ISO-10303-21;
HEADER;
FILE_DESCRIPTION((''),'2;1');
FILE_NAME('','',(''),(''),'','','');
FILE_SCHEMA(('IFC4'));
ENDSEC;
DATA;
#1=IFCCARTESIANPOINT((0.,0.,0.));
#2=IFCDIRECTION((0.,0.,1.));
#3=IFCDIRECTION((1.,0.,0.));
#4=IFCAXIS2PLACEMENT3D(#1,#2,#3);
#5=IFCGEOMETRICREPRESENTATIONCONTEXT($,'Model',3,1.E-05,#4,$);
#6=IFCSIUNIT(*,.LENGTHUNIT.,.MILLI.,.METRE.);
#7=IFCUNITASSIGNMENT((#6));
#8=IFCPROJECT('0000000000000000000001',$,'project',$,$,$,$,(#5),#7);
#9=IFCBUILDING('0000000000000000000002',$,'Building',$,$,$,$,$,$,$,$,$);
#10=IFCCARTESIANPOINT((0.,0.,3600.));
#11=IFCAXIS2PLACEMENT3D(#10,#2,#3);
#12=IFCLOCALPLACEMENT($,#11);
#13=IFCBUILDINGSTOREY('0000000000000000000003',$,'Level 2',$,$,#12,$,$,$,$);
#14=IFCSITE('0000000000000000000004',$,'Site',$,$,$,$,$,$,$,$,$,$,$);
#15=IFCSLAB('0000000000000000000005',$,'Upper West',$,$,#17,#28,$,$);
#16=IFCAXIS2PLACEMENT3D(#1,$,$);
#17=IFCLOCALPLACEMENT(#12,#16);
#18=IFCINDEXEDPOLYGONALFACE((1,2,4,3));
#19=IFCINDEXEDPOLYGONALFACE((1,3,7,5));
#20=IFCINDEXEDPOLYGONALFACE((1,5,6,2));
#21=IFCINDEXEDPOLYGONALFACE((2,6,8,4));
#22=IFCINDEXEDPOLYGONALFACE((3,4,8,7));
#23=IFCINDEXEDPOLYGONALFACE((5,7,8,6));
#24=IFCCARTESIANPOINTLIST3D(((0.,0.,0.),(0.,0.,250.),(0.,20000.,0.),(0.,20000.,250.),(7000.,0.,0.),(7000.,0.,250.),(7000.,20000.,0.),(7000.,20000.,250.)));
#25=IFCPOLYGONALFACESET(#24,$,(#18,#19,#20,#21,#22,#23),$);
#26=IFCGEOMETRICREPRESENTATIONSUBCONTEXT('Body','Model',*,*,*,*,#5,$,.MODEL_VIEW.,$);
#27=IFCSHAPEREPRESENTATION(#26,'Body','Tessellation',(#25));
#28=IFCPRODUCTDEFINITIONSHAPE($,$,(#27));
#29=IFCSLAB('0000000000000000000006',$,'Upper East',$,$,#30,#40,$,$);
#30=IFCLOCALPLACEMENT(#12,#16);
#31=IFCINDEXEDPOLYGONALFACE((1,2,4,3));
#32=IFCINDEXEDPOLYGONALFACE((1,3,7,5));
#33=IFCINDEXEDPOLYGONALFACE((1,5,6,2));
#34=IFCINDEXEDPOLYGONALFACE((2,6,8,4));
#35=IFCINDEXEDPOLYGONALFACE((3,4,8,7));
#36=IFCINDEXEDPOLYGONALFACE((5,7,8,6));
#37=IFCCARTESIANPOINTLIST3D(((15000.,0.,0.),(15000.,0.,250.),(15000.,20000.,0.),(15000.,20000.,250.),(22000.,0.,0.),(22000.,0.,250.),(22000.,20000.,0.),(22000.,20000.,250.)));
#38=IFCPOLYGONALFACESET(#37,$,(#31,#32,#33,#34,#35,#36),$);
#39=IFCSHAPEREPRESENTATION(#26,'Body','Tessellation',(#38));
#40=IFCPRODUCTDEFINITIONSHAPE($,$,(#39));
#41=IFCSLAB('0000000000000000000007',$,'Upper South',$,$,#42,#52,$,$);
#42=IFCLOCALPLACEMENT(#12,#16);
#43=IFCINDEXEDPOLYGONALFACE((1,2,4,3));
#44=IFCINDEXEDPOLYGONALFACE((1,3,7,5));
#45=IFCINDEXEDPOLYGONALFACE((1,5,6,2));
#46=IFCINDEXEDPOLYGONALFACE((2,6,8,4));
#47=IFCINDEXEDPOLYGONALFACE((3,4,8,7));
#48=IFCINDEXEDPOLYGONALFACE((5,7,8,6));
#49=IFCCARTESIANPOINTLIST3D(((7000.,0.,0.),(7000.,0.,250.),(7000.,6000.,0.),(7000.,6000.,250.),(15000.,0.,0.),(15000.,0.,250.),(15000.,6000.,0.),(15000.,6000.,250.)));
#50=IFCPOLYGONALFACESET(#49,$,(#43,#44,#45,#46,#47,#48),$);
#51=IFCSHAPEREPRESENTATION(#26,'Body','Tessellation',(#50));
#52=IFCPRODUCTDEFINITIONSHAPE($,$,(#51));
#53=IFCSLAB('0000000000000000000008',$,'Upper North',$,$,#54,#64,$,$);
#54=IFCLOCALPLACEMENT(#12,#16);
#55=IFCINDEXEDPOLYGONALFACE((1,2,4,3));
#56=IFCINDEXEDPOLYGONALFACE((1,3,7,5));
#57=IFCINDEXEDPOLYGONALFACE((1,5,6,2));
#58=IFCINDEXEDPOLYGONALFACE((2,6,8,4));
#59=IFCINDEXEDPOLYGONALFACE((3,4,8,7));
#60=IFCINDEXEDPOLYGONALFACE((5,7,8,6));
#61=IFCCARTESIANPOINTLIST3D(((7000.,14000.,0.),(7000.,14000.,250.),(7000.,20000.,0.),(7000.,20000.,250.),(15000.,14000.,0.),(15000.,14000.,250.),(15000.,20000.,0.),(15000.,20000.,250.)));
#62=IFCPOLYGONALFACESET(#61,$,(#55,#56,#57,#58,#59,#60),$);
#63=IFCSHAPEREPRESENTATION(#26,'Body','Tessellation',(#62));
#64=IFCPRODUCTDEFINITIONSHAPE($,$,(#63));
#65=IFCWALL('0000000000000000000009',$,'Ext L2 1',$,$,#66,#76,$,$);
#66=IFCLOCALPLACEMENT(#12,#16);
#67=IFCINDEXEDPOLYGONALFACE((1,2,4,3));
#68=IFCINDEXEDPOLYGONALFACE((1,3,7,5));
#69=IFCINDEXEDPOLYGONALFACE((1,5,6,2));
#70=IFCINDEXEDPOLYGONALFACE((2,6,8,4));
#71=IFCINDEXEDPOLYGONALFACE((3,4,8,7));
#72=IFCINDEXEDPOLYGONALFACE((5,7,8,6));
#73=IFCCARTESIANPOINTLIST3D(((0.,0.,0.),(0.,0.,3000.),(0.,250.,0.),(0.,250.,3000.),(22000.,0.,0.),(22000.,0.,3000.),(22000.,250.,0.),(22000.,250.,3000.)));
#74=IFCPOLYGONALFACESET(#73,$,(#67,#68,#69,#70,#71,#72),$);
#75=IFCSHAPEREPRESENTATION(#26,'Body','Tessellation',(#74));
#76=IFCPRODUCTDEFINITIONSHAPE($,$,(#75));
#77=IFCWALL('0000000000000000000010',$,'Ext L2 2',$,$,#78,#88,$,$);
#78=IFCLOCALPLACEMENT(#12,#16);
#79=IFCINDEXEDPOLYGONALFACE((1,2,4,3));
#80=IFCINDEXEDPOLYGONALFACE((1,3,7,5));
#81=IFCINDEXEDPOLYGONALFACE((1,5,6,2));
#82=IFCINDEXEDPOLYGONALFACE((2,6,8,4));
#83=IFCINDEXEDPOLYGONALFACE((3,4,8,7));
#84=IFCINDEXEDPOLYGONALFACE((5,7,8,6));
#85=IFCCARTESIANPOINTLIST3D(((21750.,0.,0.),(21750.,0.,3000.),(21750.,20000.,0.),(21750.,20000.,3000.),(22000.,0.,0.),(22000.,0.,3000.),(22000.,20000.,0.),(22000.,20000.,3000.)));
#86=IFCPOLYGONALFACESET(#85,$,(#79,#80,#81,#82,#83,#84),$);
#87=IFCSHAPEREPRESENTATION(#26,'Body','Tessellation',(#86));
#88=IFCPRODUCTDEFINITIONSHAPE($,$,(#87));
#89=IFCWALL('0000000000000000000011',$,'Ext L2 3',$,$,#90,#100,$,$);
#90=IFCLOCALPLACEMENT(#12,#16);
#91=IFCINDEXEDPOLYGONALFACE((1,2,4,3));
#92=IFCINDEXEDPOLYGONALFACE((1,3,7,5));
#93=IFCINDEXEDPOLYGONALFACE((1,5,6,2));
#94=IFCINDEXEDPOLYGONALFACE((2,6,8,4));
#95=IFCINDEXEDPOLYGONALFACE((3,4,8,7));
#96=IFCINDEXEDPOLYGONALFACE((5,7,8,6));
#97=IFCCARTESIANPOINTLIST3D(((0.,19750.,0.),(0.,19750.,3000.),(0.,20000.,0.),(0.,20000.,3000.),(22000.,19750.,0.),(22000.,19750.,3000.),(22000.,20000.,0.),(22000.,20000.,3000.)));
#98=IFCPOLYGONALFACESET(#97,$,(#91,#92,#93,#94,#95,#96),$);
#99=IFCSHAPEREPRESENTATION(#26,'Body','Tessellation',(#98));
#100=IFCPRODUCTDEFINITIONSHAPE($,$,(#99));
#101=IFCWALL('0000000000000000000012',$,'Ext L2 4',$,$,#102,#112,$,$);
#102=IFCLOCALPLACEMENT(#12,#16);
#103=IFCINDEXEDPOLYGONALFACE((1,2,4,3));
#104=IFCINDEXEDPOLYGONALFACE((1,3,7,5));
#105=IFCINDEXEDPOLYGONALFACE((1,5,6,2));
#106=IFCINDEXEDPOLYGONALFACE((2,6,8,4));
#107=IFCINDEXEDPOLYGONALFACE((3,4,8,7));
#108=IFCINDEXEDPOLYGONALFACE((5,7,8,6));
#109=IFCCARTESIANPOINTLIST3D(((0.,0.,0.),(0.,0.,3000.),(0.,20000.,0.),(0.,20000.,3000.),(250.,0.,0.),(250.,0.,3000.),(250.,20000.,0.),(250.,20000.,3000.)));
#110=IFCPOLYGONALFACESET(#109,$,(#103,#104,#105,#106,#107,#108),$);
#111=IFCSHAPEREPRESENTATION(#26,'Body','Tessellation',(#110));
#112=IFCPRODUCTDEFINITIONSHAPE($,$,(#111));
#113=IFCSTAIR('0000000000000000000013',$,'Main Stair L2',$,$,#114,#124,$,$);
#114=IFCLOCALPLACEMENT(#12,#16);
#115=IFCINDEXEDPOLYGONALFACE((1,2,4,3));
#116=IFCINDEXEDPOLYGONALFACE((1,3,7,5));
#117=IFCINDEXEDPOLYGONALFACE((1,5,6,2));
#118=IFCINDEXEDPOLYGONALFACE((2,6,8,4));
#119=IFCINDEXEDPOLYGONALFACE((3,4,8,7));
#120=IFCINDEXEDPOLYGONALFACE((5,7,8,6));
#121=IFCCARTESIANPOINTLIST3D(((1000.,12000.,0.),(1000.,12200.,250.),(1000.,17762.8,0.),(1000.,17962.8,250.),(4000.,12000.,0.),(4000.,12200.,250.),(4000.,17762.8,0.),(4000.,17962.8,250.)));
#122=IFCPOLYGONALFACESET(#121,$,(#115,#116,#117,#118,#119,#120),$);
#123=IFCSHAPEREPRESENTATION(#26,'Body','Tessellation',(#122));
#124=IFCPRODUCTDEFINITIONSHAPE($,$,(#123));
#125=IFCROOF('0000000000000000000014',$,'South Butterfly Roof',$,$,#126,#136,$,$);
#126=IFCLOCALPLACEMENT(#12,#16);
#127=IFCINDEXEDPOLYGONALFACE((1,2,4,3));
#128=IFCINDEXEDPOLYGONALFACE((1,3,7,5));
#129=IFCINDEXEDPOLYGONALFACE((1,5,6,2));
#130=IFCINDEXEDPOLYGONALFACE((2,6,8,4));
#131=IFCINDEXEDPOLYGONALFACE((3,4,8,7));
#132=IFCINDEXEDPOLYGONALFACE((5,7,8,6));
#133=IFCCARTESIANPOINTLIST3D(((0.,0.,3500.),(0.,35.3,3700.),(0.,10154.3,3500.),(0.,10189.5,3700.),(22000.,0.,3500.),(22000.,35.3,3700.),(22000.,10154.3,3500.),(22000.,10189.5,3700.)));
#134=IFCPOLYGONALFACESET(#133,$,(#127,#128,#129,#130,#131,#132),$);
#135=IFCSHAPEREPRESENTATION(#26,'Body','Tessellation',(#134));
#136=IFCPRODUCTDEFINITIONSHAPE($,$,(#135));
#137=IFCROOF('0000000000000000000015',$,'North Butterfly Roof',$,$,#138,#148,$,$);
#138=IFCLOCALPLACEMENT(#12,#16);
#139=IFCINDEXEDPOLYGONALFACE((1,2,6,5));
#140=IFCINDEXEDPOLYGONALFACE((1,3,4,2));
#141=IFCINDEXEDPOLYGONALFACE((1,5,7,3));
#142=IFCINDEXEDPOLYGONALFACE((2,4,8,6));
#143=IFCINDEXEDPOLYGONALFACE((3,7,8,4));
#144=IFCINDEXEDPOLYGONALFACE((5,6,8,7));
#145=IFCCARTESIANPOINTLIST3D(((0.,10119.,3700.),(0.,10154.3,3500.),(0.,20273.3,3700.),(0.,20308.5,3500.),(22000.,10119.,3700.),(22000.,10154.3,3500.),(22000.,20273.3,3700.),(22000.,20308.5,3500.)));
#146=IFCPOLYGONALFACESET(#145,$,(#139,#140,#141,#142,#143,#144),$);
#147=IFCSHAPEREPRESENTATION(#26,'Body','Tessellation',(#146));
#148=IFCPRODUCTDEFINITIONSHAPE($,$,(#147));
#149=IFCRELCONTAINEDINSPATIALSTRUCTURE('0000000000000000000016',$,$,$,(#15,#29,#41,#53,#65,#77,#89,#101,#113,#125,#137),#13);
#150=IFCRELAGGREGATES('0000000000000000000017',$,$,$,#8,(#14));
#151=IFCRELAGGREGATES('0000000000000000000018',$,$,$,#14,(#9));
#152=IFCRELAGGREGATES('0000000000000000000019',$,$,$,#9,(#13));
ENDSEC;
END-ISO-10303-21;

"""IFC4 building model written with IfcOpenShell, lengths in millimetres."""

from ifc_helpers import new_model, si_unit, frame, origin_with_axes, place, context, subcontext, project, spatial, indexed_curve, outline, extrude, element, save


model = new_model("IFC4")

# Units and contexts
model_context = context("Model", 3, precision=1e-05, world=origin_with_axes())
body_context = subcontext(model_context, "Body", "Model", "MODEL_VIEW")
ifc_project = project(units=[si_unit("LENGTHUNIT", "METRE", prefix="MILLI")], contexts=[model_context])

# Site, building, storey
site = spatial("IfcSite", under=ifc_project, Name="Site")
building = spatial("IfcBuilding", under=site, Name="Building")
storey_placement = place(None, frame((0.0, 0.0, 3600.0), z_axis=(0.0, 0.0, 1.0), x_axis=(1.0, 0.0, 0.0)))
storey = spatial("IfcBuildingStorey", under=building, at=storey_placement, Name="Level 2")

# Slabs
slab_1_placement = place(storey_placement, origin_with_axes())
element("IfcSlab", 1, at=slab_1_placement, inside=storey, Name="Upper West", context=body_context, shape_type="SweptSolid", body=[
    extrude(outline(indexed_curve([(0.0, 0.0), (7000.0, 0.0), (7000.0, 20000.0), (0.0, 20000.0), (0.0, 0.0)])), None, (0.0, 0.0, 1.0), 250.0),
])
slab_2_placement = place(storey_placement, origin_with_axes())
element("IfcSlab", 2, at=slab_2_placement, inside=storey, Name="Upper East", context=body_context, shape_type="SweptSolid", body=[
    extrude(outline(indexed_curve([(15000.0, 0.0), (22000.0, 0.0), (22000.0, 20000.0), (15000.0, 20000.0), (15000.0, 0.0)])), None, (0.0, 0.0, 1.0), 250.0),
])
slab_3_placement = place(storey_placement, origin_with_axes())
element("IfcSlab", 3, at=slab_3_placement, inside=storey, Name="Upper South", context=body_context, shape_type="SweptSolid", body=[
    extrude(outline(indexed_curve([(7000.0, 0.0), (15000.0, 0.0), (15000.0, 6000.0), (7000.0, 6000.0), (7000.0, 0.0)])), None, (0.0, 0.0, 1.0), 250.0),
])
slab_4_placement = place(storey_placement, origin_with_axes())
element("IfcSlab", 4, at=slab_4_placement, inside=storey, Name="Upper North", context=body_context, shape_type="SweptSolid", body=[
    extrude(outline(indexed_curve([(7000.0, 14000.0), (15000.0, 14000.0), (15000.0, 20000.0), (7000.0, 20000.0), (7000.0, 14000.0)])), None, (0.0, 0.0, 1.0), 250.0),
])

# Walls
wall_1_placement = place(storey_placement, origin_with_axes())
element("IfcWall", 5, at=wall_1_placement, inside=storey, Name="Ext L2 1", context=body_context, shape_type="SweptSolid", body=[
    extrude(outline(indexed_curve([(0.0, 0.0), (0.0, 250.0), (22000.0, 250.0), (22000.0, 0.0), (0.0, 0.0)], self_intersect=False)), origin_with_axes(), (0.0, 0.0, 1.0), 3000.0),
])
wall_2_placement = place(storey_placement, frame((22000.0, 0.0, 0.0), z_axis=(0.0, 0.0, 1.0), x_axis=(0.0, 1.0, 0.0)))
element("IfcWall", 6, at=wall_2_placement, inside=storey, Name="Ext L2 2", context=body_context, shape_type="SweptSolid", body=[
    extrude(outline(indexed_curve([(0.0, 0.0), (0.0, 250.0), (20000.0, 250.0), (20000.0, 0.0), (0.0, 0.0)], self_intersect=False)), origin_with_axes(), (0.0, 0.0, 1.0), 3000.0),
])
wall_3_placement = place(storey_placement, frame((22000.0, 20000.0, 0.0), z_axis=(0.0, 0.0, 1.0), x_axis=(-1.0, 0.0, 0.0)))
element("IfcWall", 7, at=wall_3_placement, inside=storey, Name="Ext L2 3", context=body_context, shape_type="SweptSolid", body=[
    extrude(outline(indexed_curve([(0.0, 0.0), (0.0, 250.0), (22000.0, 250.0), (22000.0, 0.0), (0.0, 0.0)], self_intersect=False)), origin_with_axes(), (0.0, 0.0, 1.0), 3000.0),
])
wall_4_placement = place(storey_placement, frame((0.0, 20000.0, 0.0), z_axis=(0.0, 0.0, 1.0), x_axis=(0.0, -1.0, 0.0)))
element("IfcWall", 8, at=wall_4_placement, inside=storey, Name="Ext L2 4", context=body_context, shape_type="SweptSolid", body=[
    extrude(outline(indexed_curve([(0.0, 0.0), (0.0, 250.0), (20000.0, 250.0), (20000.0, 0.0), (0.0, 0.0)], self_intersect=False)), origin_with_axes(), (0.0, 0.0, 1.0), 3000.0),
])

# Stair
stair_placement = place(storey_placement, frame((1000.0, 12000.0, 0.0), z_axis=(0.0, 0.0, 1.0), x_axis=(1.0, 0.0, 0.0)))
element("IfcStair", 9, at=stair_placement, inside=storey, Name="Main Stair L2", context=body_context, shape_type="SweptSolid", body=[
    extrude(outline(indexed_curve([(0.0, 0.0), (3000.0, 0.0), (3000.0, 5762.8), (0.0, 5762.8), (0.0, 0.0)])), None, (0.0, 0.624695, 0.780869), 320.2),
])

# Roofs
roof_1_placement = place(storey_placement, frame((0.0, 0.0, 3500.0), z_axis=(0.0, 0.0, 1.0), x_axis=(1.0, 0.0, 0.0)))
element("IfcRoof", 10, at=roof_1_placement, inside=storey, Name="South Butterfly Roof", context=body_context, shape_type="SweptSolid", body=[
    extrude(outline(indexed_curve([(0.0, 0.0), (22000.0, 0.0), (22000.0, 10154.3), (0.0, 10154.3), (0.0, 0.0)])), None, (0.0, 0.173648, 0.984808), 203.1),
])
roof_2_placement = place(storey_placement, frame((0.0, 0.0, 3500.0), z_axis=(0.0, 0.0, 1.0), x_axis=(1.0, 0.0, 0.0)))
element("IfcRoof", 11, at=roof_2_placement, inside=storey, Name="North Butterfly Roof", context=body_context, shape_type="SweptSolid", body=[
    extrude(outline(indexed_curve([(0.0, 10154.3), (22000.0, 10154.3), (22000.0, 20308.5), (0.0, 20308.5), (0.0, 10154.3)])), None, (0.0, -0.173648, 0.984808), 203.1),
])

save(model, "model.ifc")
